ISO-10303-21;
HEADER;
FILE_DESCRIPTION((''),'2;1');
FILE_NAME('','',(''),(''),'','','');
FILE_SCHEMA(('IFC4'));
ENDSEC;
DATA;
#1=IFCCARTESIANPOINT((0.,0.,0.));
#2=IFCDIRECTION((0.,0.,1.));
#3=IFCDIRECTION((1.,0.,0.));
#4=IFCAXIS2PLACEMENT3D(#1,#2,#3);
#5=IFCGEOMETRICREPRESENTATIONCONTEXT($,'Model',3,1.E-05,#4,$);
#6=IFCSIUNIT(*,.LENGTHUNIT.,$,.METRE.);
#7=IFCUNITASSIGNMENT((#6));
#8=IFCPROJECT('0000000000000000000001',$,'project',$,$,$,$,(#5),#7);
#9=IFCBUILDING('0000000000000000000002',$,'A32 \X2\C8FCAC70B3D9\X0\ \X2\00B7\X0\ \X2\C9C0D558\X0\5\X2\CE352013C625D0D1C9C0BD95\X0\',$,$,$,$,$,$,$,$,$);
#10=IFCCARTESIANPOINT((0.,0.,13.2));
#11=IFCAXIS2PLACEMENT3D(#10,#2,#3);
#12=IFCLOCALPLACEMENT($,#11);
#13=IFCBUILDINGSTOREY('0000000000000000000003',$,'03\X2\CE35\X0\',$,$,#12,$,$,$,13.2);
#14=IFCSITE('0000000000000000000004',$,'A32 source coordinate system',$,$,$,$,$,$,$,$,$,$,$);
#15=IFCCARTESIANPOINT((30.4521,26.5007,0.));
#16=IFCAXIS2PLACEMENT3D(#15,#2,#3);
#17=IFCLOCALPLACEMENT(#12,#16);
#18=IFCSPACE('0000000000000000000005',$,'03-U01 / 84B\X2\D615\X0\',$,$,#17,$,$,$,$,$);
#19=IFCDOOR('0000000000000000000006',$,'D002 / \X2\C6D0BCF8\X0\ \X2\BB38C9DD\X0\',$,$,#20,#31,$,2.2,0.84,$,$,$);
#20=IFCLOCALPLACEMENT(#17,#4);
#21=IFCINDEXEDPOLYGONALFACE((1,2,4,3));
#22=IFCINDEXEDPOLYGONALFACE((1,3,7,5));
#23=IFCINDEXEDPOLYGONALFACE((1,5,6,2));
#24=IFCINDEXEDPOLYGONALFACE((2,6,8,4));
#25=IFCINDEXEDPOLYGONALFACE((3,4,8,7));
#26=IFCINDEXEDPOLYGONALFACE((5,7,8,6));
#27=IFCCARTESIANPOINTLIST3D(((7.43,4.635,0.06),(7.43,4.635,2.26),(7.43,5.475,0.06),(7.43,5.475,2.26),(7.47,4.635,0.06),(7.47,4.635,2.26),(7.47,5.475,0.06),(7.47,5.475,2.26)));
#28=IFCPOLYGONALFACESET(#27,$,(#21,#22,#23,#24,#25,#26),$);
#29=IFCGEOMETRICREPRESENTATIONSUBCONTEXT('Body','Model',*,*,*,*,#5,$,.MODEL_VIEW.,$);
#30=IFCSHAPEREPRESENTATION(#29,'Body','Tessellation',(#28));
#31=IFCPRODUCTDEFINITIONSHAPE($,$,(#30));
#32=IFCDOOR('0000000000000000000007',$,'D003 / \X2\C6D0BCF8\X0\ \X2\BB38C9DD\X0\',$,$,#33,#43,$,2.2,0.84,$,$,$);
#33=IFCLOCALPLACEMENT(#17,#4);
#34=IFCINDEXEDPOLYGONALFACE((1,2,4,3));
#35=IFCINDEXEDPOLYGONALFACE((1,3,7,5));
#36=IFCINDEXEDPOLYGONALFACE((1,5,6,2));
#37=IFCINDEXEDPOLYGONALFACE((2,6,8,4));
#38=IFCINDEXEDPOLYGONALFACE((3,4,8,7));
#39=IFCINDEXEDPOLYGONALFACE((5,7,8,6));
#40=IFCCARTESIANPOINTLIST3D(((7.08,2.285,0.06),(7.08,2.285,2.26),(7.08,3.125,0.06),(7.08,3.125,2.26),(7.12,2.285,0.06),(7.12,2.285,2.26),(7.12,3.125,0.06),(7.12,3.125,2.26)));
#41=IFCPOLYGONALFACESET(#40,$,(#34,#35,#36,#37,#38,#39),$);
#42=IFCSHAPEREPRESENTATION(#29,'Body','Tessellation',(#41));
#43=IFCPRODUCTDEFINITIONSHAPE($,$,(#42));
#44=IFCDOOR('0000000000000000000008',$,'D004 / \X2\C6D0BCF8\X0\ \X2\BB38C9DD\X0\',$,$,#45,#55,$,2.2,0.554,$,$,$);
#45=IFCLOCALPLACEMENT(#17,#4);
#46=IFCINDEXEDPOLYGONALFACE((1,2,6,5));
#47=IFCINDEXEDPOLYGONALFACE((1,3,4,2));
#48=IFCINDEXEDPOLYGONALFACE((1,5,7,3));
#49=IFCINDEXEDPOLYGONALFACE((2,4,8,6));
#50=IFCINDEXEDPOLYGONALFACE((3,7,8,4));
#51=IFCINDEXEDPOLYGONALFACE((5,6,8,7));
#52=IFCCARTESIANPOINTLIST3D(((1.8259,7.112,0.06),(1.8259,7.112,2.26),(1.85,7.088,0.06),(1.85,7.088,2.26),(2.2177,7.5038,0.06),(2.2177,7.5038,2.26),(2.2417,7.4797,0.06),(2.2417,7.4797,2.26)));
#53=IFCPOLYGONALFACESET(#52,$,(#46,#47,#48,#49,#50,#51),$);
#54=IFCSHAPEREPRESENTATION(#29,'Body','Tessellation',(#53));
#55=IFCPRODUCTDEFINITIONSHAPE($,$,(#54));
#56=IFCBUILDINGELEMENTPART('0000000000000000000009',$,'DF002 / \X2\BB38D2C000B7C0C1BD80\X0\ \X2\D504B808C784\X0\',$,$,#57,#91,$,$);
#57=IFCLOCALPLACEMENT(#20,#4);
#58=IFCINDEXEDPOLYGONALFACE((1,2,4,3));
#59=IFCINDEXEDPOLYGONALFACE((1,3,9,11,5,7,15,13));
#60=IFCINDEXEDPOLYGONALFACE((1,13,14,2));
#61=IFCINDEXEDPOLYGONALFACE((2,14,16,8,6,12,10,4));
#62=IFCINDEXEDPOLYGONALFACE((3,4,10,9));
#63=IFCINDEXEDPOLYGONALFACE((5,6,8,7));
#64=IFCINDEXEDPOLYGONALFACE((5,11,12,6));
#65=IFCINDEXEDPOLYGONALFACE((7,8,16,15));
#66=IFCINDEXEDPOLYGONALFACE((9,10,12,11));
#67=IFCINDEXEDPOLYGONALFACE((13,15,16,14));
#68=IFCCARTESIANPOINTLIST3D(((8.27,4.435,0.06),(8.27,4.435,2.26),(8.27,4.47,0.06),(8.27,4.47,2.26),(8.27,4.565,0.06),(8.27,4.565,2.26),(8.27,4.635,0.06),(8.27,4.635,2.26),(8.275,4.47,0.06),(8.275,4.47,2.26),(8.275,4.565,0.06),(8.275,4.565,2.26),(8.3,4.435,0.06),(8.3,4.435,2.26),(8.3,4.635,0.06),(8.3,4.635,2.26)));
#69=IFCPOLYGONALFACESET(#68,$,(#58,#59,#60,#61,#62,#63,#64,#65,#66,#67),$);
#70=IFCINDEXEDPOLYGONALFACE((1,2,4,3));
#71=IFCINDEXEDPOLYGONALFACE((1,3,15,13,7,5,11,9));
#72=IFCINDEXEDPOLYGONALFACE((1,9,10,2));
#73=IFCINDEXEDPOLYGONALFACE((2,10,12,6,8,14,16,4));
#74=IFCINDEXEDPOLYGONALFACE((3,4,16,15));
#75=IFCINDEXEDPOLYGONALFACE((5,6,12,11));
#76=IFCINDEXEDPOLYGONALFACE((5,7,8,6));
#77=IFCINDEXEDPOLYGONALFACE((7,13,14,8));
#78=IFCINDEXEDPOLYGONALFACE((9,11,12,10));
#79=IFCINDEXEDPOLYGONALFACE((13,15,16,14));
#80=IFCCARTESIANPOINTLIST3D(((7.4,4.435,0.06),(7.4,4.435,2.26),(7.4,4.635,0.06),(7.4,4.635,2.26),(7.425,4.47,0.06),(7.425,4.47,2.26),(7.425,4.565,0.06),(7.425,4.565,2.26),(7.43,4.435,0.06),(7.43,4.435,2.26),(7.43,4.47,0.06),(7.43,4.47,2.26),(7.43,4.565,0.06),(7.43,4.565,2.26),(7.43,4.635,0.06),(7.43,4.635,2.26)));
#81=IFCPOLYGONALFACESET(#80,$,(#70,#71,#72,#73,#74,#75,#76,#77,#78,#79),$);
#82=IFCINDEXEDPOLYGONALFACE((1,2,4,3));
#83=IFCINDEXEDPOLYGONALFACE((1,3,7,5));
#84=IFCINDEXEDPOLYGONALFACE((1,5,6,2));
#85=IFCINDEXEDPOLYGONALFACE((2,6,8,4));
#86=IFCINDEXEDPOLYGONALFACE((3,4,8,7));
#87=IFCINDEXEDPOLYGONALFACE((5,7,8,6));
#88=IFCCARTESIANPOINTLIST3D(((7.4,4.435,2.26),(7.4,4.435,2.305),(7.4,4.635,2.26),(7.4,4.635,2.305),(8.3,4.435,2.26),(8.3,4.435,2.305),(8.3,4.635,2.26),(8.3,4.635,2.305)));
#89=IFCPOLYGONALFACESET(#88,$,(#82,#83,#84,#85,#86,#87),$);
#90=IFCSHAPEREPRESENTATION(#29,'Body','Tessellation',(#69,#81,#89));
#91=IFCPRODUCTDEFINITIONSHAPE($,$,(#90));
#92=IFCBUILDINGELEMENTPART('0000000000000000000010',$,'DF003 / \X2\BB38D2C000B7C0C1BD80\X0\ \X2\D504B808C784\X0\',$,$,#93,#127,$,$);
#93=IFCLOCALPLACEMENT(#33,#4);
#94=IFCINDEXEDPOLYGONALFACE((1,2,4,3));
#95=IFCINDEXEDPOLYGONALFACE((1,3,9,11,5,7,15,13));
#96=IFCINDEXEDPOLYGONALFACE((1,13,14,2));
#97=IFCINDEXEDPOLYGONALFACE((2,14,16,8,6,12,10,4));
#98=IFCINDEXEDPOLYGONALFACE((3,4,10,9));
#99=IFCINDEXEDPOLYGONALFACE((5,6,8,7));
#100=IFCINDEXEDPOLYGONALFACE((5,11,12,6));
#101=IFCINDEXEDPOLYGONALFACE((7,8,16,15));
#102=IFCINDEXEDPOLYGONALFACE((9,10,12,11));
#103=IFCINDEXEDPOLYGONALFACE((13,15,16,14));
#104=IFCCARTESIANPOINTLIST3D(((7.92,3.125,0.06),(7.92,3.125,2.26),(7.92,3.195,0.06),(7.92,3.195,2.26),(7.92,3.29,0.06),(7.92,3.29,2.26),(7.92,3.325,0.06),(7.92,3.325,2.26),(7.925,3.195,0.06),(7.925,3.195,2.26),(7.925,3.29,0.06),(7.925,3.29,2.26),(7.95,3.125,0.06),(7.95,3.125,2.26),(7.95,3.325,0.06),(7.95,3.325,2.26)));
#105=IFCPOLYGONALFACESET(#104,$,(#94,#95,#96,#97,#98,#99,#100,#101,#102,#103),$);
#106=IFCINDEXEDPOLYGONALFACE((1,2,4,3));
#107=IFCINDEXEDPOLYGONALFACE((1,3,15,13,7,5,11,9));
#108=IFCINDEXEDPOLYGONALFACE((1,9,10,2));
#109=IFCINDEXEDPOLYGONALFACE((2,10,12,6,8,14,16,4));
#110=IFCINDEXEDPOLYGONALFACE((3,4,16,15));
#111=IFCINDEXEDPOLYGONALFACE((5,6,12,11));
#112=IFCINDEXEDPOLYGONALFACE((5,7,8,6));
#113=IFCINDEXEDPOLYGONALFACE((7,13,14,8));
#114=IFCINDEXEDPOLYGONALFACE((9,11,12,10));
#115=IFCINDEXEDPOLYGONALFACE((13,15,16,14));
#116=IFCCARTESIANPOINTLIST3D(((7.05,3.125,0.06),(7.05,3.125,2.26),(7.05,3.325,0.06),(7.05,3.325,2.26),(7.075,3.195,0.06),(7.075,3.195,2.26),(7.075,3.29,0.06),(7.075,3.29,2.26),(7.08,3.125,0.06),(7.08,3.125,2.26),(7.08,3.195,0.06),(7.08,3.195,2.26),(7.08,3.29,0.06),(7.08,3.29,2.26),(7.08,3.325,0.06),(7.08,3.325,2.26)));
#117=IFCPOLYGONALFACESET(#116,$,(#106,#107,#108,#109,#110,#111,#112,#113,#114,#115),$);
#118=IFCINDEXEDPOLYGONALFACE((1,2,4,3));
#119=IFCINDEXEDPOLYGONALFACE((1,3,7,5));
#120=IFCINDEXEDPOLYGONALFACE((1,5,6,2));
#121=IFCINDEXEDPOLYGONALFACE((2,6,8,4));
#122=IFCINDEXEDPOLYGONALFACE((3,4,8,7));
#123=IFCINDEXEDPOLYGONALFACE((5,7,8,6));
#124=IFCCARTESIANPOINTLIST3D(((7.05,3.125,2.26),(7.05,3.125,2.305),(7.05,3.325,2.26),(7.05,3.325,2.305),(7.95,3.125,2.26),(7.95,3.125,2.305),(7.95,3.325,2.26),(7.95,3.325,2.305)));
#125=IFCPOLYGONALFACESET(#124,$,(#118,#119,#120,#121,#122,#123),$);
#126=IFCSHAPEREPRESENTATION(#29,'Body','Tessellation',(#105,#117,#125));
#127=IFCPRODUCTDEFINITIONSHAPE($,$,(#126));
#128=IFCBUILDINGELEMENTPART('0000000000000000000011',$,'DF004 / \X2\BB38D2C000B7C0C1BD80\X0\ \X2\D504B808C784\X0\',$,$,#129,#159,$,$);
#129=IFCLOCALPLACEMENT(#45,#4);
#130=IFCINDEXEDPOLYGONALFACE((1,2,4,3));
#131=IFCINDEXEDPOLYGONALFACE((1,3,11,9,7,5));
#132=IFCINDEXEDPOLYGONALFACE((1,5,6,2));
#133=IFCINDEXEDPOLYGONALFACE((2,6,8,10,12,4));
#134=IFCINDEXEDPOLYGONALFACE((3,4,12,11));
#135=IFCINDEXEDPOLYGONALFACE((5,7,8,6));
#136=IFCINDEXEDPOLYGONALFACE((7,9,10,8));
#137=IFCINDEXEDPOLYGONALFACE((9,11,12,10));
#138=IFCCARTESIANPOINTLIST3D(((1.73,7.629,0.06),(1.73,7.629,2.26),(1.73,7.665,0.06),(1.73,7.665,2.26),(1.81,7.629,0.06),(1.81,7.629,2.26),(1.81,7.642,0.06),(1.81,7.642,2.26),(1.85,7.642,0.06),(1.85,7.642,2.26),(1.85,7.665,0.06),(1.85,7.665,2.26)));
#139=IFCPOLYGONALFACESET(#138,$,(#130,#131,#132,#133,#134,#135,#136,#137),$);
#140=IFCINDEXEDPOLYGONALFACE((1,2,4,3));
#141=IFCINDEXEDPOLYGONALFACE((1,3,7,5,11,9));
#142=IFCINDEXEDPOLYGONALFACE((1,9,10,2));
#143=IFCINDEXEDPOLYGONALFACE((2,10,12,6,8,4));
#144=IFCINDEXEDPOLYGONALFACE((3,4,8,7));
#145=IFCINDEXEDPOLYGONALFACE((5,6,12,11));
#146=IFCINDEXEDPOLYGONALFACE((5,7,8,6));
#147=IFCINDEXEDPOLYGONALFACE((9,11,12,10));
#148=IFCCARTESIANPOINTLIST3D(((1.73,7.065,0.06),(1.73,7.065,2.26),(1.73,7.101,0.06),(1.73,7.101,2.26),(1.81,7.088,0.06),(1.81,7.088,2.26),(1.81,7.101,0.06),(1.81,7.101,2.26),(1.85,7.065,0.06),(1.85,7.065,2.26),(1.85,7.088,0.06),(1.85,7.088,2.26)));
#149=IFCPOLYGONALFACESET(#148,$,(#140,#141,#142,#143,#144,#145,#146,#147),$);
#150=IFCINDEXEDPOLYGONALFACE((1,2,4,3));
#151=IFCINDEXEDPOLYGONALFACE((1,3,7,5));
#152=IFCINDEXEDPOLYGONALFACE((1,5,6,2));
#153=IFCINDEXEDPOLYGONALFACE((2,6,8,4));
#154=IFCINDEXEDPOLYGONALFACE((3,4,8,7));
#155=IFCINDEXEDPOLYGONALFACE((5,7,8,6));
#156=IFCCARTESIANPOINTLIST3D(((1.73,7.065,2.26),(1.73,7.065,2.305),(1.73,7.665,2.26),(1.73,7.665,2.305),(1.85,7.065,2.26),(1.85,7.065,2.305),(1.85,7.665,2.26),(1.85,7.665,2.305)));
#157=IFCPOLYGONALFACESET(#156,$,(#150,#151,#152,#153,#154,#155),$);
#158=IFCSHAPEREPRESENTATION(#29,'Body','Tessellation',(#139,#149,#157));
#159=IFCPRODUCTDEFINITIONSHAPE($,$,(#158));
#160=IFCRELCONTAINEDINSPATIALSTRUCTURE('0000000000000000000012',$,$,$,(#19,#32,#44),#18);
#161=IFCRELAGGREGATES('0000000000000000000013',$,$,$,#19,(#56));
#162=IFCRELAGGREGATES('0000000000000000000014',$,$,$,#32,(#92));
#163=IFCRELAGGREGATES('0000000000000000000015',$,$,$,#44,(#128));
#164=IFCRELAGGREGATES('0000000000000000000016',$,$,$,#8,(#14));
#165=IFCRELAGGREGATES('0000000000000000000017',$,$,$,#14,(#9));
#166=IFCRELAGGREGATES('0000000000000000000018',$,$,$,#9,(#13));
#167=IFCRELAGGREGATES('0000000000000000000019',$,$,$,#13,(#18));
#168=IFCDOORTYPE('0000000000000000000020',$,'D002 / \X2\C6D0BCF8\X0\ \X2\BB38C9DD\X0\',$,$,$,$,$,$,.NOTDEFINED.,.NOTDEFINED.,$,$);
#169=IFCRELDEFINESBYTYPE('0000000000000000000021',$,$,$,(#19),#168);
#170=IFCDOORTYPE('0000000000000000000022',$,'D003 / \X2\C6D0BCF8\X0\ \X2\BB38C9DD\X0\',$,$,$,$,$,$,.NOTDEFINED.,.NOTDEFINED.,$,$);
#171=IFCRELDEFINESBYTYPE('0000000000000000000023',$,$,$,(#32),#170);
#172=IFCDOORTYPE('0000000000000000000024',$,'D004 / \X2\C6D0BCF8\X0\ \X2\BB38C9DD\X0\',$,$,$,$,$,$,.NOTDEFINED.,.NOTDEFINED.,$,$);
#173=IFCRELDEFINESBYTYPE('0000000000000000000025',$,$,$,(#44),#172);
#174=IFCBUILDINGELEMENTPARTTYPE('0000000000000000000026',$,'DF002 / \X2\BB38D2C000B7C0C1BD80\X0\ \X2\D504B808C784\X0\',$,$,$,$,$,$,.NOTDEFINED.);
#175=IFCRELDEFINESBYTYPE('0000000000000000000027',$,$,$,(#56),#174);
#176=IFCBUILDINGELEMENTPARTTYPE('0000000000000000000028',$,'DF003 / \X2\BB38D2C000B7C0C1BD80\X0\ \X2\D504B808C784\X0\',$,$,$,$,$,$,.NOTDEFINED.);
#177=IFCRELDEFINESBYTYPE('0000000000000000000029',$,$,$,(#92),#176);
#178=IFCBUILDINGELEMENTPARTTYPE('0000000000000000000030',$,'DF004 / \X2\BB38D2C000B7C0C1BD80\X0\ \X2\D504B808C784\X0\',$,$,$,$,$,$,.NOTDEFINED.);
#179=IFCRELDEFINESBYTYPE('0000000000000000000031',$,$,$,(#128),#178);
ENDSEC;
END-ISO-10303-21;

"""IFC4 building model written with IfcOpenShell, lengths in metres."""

from ifc_helpers import new_model, si_unit, frame, origin, origin_with_axes, place, context, subcontext, project, spatial, polyline, outline, extrude, source, transform, mapped, type_object, type_shapes, element, aggregate, save


model = new_model("IFC4")

# Units and contexts
model_context = context("Model", 3, precision=1e-05, world=origin_with_axes())
body_context = subcontext(model_context, "Body", "Model", "MODEL_VIEW")
ifc_project = project(units=[si_unit("LENGTHUNIT", "METRE")], contexts=[model_context])

# Site, building, storey, space
storey_placement = place(None, frame((0.0, 0.0, 13.2), z_axis=(0.0, 0.0, 1.0), x_axis=(1.0, 0.0, 0.0)))
space_placement = place(storey_placement, frame((30.4521, 26.5007, 0.0), z_axis=(0.0, 0.0, 1.0), x_axis=(1.0, 0.0, 0.0)))
site = spatial("IfcSite", under=ifc_project, Name="A32 source coordinate system")
building = spatial("IfcBuilding", under=site, Name="A32 주거동 · 지하5층–옥탑지붕")
storey = spatial("IfcBuildingStorey", under=building, at=storey_placement, Name="03층", Elevation=13.2)
space = spatial("IfcSpace", under=storey, at=space_placement, Name="03-U01 / 84B형")

# Doors
door_type_1 = type_object("IfcDoorType", Name="D002 / 원본 문짝", OperationType="NOTDEFINED", PredefinedType="NOTDEFINED")
shared_shape_1 = source(origin(), body_context, "Body", "SweptSolid", [
    extrude(outline(polyline([(7.43, 4.635), (7.43, 5.475), (7.47, 5.475), (7.47, 4.635), (7.43, 4.635)])), frame((0.0, 0.0, 0.06)), (0.0, 0.0, 1.0), 2.2),
])
type_shapes(door_type_1, [shared_shape_1])
door_1_placement = place(space_placement, origin_with_axes())
door_1 = element("IfcDoor", 1, at=door_1_placement, inside=space, type_object=door_type_1, Name="D002 / 원본 문짝", OverallHeight=2.2, OverallWidth=0.84, context=body_context, shape_type="MappedRepresentation", body=[
    mapped(shared_shape_1, transform((0.0, 0.0, 0.0), scale=1.0)),
])
door_type_2 = type_object("IfcDoorType", Name="D003 / 원본 문짝", OperationType="NOTDEFINED", PredefinedType="NOTDEFINED")
shared_shape_2 = source(origin(), body_context, "Body", "SweptSolid", [
    extrude(outline(polyline([(7.12, 2.285), (7.08, 2.285), (7.08, 3.125), (7.12, 3.125), (7.12, 2.285)])), frame((0.0, 0.0, 0.06)), (0.0, 0.0, 1.0), 2.2),
])
type_shapes(door_type_2, [shared_shape_2])
door_2_placement = place(space_placement, origin_with_axes())
door_2 = element("IfcDoor", 2, at=door_2_placement, inside=space, type_object=door_type_2, Name="D003 / 원본 문짝", OverallHeight=2.2, OverallWidth=0.84, context=body_context, shape_type="MappedRepresentation", body=[
    mapped(shared_shape_2, transform((0.0, 0.0, 0.0), scale=1.0)),
])
door_type_3 = type_object("IfcDoorType", Name="D004 / 원본 문짝", OperationType="NOTDEFINED", PredefinedType="NOTDEFINED")
shared_shape_3 = source(origin(), body_context, "Body", "SweptSolid", [
    extrude(outline(polyline([(2.2177, 7.5038), (2.2417, 7.4797), (1.85, 7.088), (1.8259, 7.112), (2.2177, 7.5038)])), frame((0.0, 0.0, 0.06)), (0.0, 0.0, 1.0), 2.2),
])
type_shapes(door_type_3, [shared_shape_3])
door_3_placement = place(space_placement, origin_with_axes())
door_3 = element("IfcDoor", 3, at=door_3_placement, inside=space, type_object=door_type_3, Name="D004 / 원본 문짝", OverallHeight=2.2, OverallWidth=0.554, context=body_context, shape_type="MappedRepresentation", body=[
    mapped(shared_shape_3, transform((0.0, 0.0, 0.0), scale=1.0)),
])

# Building element parts
building_element_part_type_1 = type_object("IfcBuildingElementPartType", Name="DF002 / 문틀·상부 프레임", PredefinedType="NOTDEFINED")
shared_shape_4 = source(origin(), body_context, "Body", "SweptSolid", [
    extrude(outline(polyline([(8.3, 4.435), (8.27, 4.435), (8.27, 4.47), (8.275, 4.47), (8.275, 4.565), (8.27, 4.565), (8.27, 4.635), (8.3, 4.635), (8.3, 4.435)])), frame((0.0, 0.0, 0.06)), (0.0, 0.0, 1.0), 2.2),
    extrude(outline(polyline([(7.43, 4.635), (7.43, 4.565), (7.425, 4.565), (7.425, 4.47), (7.43, 4.47), (7.43, 4.435), (7.4, 4.435), (7.4, 4.635), (7.43, 4.635)])), frame((0.0, 0.0, 0.06)), (0.0, 0.0, 1.0), 2.2),
    extrude(outline(polyline([(7.4, 4.435), (7.4, 4.635), (8.3, 4.635), (8.3, 4.435), (7.4, 4.435)])), frame((0.0, 0.0, 2.26)), (0.0, 0.0, 1.0), 0.045),
])
type_shapes(building_element_part_type_1, [shared_shape_4])
building_element_part_1_placement = place(door_1_placement, origin_with_axes())
building_element_part_1 = element("IfcBuildingElementPart", 4, at=building_element_part_1_placement, type_object=building_element_part_type_1, Name="DF002 / 문틀·상부 프레임", context=body_context, shape_type="MappedRepresentation", body=[
    mapped(shared_shape_4, transform((0.0, 0.0, 0.0), scale=1.0)),
])
aggregate(door_1, [building_element_part_1])
building_element_part_type_2 = type_object("IfcBuildingElementPartType", Name="DF003 / 문틀·상부 프레임", PredefinedType="NOTDEFINED")
shared_shape_5 = source(origin(), body_context, "Body", "SweptSolid", [
    extrude(outline(polyline([(7.92, 3.125), (7.92, 3.195), (7.925, 3.195), (7.925, 3.29), (7.92, 3.29), (7.92, 3.325), (7.95, 3.325), (7.95, 3.125), (7.92, 3.125)])), frame((0.0, 0.0, 0.06)), (0.0, 0.0, 1.0), 2.2),
    extrude(outline(polyline([(7.05, 3.325), (7.08, 3.325), (7.08, 3.29), (7.075, 3.29), (7.075, 3.195), (7.08, 3.195), (7.08, 3.125), (7.05, 3.125), (7.05, 3.325)])), frame((0.0, 0.0, 0.06)), (0.0, 0.0, 1.0), 2.2),
    extrude(outline(polyline([(7.05, 3.125), (7.05, 3.325), (7.95, 3.325), (7.95, 3.125), (7.05, 3.125)])), frame((0.0, 0.0, 2.26)), (0.0, 0.0, 1.0), 0.045),
])
type_shapes(building_element_part_type_2, [shared_shape_5])
building_element_part_2_placement = place(door_2_placement, origin_with_axes())
building_element_part_2 = element("IfcBuildingElementPart", 5, at=building_element_part_2_placement, type_object=building_element_part_type_2, Name="DF003 / 문틀·상부 프레임", context=body_context, shape_type="MappedRepresentation", body=[
    mapped(shared_shape_5, transform((0.0, 0.0, 0.0), scale=1.0)),
])
aggregate(door_2, [building_element_part_2])
building_element_part_type_3 = type_object("IfcBuildingElementPartType", Name="DF004 / 문틀·상부 프레임", PredefinedType="NOTDEFINED")
shared_shape_6 = source(origin(), body_context, "Body", "SweptSolid", [
    extrude(outline(polyline([(1.85, 7.665), (1.85, 7.642), (1.81, 7.642), (1.81, 7.629), (1.73, 7.629), (1.73, 7.665), (1.85, 7.665)])), frame((0.0, 0.0, 0.06)), (0.0, 0.0, 1.0), 2.2),
    extrude(outline(polyline([(1.73, 7.101), (1.81, 7.101), (1.81, 7.088), (1.85, 7.088), (1.85, 7.065), (1.73, 7.065), (1.73, 7.101)])), frame((0.0, 0.0, 0.06)), (0.0, 0.0, 1.0), 2.2),
    extrude(outline(polyline([(1.73, 7.065), (1.73, 7.665), (1.85, 7.665), (1.85, 7.065), (1.73, 7.065)])), frame((0.0, 0.0, 2.26)), (0.0, 0.0, 1.0), 0.045),
])
type_shapes(building_element_part_type_3, [shared_shape_6])
building_element_part_3_placement = place(door_3_placement, origin_with_axes())
building_element_part_3 = element("IfcBuildingElementPart", 6, at=building_element_part_3_placement, type_object=building_element_part_type_3, Name="DF004 / 문틀·상부 프레임", context=body_context, shape_type="MappedRepresentation", body=[
    mapped(shared_shape_6, transform((0.0, 0.0, 0.0), scale=1.0)),
])
aggregate(door_3, [building_element_part_3])

save(model, "model.ifc")
